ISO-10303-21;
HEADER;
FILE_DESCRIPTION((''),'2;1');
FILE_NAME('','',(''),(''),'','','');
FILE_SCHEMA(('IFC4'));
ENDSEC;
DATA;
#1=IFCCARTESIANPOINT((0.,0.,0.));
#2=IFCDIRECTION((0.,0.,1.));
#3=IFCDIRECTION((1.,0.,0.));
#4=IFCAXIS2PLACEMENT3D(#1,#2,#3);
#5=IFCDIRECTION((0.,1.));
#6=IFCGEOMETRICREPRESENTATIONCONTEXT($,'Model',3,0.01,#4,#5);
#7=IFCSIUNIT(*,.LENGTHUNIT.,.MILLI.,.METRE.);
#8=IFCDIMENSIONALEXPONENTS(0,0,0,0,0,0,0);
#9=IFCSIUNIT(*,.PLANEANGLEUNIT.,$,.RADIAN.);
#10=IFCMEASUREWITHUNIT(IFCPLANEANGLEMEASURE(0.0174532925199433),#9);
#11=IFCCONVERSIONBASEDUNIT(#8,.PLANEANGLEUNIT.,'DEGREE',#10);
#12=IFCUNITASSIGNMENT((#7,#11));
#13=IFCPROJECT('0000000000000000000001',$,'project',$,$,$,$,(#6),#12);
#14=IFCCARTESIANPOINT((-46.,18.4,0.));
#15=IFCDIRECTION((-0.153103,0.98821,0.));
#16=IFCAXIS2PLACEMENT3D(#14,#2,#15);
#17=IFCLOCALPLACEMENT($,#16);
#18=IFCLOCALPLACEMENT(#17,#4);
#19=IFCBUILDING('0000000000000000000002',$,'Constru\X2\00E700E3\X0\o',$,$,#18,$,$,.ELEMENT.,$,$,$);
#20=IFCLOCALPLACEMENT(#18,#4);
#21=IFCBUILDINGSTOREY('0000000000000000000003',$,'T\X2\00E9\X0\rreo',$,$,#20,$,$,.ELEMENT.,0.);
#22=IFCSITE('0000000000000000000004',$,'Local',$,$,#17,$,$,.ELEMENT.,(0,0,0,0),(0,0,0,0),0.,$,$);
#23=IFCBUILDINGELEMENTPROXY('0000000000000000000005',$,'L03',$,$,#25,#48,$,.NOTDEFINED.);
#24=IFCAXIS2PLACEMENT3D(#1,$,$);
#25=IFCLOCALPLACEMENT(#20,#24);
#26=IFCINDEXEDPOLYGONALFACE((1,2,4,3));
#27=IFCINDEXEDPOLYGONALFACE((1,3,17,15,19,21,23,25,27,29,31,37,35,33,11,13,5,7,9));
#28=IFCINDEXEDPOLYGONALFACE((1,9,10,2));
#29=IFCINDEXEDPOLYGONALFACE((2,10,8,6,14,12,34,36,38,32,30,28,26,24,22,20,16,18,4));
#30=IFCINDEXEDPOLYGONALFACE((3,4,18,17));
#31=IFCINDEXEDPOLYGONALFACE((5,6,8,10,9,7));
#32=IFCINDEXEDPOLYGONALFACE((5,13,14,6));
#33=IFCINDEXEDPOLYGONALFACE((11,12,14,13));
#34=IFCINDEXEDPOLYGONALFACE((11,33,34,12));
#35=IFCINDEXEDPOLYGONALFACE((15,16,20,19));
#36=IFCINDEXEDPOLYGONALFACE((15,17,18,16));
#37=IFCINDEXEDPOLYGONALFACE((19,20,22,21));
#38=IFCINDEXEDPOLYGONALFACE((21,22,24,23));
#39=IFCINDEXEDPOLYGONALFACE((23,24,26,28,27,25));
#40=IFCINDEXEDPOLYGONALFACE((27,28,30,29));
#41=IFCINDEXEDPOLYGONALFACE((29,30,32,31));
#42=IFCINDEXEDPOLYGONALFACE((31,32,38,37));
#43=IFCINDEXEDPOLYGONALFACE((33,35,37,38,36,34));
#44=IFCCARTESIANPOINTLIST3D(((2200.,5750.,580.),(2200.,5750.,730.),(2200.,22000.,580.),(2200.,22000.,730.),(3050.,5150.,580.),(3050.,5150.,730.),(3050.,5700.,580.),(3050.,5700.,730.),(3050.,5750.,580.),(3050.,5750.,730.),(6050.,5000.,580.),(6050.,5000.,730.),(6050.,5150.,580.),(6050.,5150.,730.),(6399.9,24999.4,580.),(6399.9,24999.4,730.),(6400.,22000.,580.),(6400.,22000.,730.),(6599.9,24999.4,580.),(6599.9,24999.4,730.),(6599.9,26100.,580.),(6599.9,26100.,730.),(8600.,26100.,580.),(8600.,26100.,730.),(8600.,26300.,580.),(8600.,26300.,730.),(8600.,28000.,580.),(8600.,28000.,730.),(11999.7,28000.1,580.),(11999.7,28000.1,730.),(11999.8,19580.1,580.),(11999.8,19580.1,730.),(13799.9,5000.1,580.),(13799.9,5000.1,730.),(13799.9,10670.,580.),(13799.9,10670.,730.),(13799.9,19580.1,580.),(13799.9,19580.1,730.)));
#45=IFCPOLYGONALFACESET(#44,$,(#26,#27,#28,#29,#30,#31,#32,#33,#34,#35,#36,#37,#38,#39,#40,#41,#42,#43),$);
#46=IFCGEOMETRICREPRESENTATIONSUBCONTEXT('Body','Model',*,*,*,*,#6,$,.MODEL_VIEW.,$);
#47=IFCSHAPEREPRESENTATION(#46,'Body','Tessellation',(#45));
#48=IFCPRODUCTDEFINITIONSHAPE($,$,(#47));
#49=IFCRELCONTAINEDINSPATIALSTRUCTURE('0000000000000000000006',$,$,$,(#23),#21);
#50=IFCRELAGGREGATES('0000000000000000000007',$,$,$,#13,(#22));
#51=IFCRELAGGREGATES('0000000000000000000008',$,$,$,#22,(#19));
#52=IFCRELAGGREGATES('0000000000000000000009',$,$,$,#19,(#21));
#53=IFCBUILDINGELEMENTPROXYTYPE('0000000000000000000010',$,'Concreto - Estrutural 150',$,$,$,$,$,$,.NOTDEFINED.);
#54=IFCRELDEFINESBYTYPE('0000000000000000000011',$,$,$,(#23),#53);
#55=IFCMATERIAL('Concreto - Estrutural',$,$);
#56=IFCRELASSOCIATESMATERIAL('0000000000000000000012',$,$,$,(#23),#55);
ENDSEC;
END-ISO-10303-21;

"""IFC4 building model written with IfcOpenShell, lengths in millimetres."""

from ifc_helpers import new_model, entity, si_unit, converted_unit, direction, frame, origin_with_axes, place, context, subcontext, project, spatial, line, indexed_curve, outline, extrude, material, type_object, element, save


model = new_model("IFC4")

# Units and contexts
model_context = context("Model", 3, precision=0.01, world=origin_with_axes(), true_north=direction((0.0, 1.0)))
body_context = subcontext(model_context, "Body", "Model", "MODEL_VIEW")
ifc_project = project(units=[si_unit("LENGTHUNIT", "METRE", prefix="MILLI"), converted_unit("PLANEANGLEUNIT", "DEGREE", entity("IfcPlaneAngleMeasure", 0.0174532925199433), si_unit("PLANEANGLEUNIT", "RADIAN"), dimensions=[0, 0, 0, 0, 0, 0, 0])], contexts=[model_context])

# Site, building, storey
site_placement = place(None, frame((-46.0, 18.4, 0.0), z_axis=(0.0, 0.0, 1.0), x_axis=(-0.153103, 0.98821, 0.0)))
site = spatial("IfcSite", under=ifc_project, at=site_placement, Name="Local", CompositionType="ELEMENT", RefLatitude=(0, 0, 0, 0), RefLongitude=(0, 0, 0, 0), RefElevation=0.0)
building_placement = place(site_placement, origin_with_axes())
building = spatial("IfcBuilding", under=site, at=building_placement, Name="Construção", CompositionType="ELEMENT")
storey_placement = place(building_placement, origin_with_axes())
storey = spatial("IfcBuildingStorey", under=building, at=storey_placement, Name="Térreo", CompositionType="ELEMENT", Elevation=0.0)

# Building element proxy
ifc_material_1 = material(Name="Concreto - Estrutural")
building_element_proxy_type_1 = type_object("IfcBuildingElementProxyType", Name="Concreto - Estrutural 150", PredefinedType="NOTDEFINED")
proxy_1_placement = place(storey_placement, frame((2200.0, 5750.0, 730.0), z_axis=(0.0, 0.0, 1.0), x_axis=(1.0, 0.0, 0.0)))
element("IfcBuildingElementProxy", 1, at=proxy_1_placement, inside=storey, type_object=building_element_proxy_type_1, material=ifc_material_1, Name="L03", PredefinedType="NOTDEFINED", context=body_context, shape_type="SweptSolid", body=[
    extrude(outline(indexed_curve([(0.0, 0.0), (850.0, 0.0), (850.0, -50.0), (850.0, -600.0), (3850.0, -600.0), (3850.0, -750.0), (11599.9, -750.0), (11599.9, 4920.0), (11599.9, 13830.1), (9799.8, 13830.1), (9799.7, 22250.1), (6400.0, 22250.0), (6400.0, 20550.0), (6400.0, 20350.0), (4399.9, 20350.0), (4399.9, 19249.4), (4199.9, 19249.4), (4200.0, 16250.0), (0.0, 16250.0)], segments=[line(1, 2, 3, 4, 5, 6, 7, 8, 9, 10, 11, 12, 13, 14, 15, 16, 17, 18, 19, 1)])), frame((0.0, 0.0, -150.0), z_axis=(0.0, 0.0, 1.0), x_axis=(1.0, 0.0, 0.0)), (0.0, 0.0, 1.0), 150.0),
])

save(model, "model.ifc")
